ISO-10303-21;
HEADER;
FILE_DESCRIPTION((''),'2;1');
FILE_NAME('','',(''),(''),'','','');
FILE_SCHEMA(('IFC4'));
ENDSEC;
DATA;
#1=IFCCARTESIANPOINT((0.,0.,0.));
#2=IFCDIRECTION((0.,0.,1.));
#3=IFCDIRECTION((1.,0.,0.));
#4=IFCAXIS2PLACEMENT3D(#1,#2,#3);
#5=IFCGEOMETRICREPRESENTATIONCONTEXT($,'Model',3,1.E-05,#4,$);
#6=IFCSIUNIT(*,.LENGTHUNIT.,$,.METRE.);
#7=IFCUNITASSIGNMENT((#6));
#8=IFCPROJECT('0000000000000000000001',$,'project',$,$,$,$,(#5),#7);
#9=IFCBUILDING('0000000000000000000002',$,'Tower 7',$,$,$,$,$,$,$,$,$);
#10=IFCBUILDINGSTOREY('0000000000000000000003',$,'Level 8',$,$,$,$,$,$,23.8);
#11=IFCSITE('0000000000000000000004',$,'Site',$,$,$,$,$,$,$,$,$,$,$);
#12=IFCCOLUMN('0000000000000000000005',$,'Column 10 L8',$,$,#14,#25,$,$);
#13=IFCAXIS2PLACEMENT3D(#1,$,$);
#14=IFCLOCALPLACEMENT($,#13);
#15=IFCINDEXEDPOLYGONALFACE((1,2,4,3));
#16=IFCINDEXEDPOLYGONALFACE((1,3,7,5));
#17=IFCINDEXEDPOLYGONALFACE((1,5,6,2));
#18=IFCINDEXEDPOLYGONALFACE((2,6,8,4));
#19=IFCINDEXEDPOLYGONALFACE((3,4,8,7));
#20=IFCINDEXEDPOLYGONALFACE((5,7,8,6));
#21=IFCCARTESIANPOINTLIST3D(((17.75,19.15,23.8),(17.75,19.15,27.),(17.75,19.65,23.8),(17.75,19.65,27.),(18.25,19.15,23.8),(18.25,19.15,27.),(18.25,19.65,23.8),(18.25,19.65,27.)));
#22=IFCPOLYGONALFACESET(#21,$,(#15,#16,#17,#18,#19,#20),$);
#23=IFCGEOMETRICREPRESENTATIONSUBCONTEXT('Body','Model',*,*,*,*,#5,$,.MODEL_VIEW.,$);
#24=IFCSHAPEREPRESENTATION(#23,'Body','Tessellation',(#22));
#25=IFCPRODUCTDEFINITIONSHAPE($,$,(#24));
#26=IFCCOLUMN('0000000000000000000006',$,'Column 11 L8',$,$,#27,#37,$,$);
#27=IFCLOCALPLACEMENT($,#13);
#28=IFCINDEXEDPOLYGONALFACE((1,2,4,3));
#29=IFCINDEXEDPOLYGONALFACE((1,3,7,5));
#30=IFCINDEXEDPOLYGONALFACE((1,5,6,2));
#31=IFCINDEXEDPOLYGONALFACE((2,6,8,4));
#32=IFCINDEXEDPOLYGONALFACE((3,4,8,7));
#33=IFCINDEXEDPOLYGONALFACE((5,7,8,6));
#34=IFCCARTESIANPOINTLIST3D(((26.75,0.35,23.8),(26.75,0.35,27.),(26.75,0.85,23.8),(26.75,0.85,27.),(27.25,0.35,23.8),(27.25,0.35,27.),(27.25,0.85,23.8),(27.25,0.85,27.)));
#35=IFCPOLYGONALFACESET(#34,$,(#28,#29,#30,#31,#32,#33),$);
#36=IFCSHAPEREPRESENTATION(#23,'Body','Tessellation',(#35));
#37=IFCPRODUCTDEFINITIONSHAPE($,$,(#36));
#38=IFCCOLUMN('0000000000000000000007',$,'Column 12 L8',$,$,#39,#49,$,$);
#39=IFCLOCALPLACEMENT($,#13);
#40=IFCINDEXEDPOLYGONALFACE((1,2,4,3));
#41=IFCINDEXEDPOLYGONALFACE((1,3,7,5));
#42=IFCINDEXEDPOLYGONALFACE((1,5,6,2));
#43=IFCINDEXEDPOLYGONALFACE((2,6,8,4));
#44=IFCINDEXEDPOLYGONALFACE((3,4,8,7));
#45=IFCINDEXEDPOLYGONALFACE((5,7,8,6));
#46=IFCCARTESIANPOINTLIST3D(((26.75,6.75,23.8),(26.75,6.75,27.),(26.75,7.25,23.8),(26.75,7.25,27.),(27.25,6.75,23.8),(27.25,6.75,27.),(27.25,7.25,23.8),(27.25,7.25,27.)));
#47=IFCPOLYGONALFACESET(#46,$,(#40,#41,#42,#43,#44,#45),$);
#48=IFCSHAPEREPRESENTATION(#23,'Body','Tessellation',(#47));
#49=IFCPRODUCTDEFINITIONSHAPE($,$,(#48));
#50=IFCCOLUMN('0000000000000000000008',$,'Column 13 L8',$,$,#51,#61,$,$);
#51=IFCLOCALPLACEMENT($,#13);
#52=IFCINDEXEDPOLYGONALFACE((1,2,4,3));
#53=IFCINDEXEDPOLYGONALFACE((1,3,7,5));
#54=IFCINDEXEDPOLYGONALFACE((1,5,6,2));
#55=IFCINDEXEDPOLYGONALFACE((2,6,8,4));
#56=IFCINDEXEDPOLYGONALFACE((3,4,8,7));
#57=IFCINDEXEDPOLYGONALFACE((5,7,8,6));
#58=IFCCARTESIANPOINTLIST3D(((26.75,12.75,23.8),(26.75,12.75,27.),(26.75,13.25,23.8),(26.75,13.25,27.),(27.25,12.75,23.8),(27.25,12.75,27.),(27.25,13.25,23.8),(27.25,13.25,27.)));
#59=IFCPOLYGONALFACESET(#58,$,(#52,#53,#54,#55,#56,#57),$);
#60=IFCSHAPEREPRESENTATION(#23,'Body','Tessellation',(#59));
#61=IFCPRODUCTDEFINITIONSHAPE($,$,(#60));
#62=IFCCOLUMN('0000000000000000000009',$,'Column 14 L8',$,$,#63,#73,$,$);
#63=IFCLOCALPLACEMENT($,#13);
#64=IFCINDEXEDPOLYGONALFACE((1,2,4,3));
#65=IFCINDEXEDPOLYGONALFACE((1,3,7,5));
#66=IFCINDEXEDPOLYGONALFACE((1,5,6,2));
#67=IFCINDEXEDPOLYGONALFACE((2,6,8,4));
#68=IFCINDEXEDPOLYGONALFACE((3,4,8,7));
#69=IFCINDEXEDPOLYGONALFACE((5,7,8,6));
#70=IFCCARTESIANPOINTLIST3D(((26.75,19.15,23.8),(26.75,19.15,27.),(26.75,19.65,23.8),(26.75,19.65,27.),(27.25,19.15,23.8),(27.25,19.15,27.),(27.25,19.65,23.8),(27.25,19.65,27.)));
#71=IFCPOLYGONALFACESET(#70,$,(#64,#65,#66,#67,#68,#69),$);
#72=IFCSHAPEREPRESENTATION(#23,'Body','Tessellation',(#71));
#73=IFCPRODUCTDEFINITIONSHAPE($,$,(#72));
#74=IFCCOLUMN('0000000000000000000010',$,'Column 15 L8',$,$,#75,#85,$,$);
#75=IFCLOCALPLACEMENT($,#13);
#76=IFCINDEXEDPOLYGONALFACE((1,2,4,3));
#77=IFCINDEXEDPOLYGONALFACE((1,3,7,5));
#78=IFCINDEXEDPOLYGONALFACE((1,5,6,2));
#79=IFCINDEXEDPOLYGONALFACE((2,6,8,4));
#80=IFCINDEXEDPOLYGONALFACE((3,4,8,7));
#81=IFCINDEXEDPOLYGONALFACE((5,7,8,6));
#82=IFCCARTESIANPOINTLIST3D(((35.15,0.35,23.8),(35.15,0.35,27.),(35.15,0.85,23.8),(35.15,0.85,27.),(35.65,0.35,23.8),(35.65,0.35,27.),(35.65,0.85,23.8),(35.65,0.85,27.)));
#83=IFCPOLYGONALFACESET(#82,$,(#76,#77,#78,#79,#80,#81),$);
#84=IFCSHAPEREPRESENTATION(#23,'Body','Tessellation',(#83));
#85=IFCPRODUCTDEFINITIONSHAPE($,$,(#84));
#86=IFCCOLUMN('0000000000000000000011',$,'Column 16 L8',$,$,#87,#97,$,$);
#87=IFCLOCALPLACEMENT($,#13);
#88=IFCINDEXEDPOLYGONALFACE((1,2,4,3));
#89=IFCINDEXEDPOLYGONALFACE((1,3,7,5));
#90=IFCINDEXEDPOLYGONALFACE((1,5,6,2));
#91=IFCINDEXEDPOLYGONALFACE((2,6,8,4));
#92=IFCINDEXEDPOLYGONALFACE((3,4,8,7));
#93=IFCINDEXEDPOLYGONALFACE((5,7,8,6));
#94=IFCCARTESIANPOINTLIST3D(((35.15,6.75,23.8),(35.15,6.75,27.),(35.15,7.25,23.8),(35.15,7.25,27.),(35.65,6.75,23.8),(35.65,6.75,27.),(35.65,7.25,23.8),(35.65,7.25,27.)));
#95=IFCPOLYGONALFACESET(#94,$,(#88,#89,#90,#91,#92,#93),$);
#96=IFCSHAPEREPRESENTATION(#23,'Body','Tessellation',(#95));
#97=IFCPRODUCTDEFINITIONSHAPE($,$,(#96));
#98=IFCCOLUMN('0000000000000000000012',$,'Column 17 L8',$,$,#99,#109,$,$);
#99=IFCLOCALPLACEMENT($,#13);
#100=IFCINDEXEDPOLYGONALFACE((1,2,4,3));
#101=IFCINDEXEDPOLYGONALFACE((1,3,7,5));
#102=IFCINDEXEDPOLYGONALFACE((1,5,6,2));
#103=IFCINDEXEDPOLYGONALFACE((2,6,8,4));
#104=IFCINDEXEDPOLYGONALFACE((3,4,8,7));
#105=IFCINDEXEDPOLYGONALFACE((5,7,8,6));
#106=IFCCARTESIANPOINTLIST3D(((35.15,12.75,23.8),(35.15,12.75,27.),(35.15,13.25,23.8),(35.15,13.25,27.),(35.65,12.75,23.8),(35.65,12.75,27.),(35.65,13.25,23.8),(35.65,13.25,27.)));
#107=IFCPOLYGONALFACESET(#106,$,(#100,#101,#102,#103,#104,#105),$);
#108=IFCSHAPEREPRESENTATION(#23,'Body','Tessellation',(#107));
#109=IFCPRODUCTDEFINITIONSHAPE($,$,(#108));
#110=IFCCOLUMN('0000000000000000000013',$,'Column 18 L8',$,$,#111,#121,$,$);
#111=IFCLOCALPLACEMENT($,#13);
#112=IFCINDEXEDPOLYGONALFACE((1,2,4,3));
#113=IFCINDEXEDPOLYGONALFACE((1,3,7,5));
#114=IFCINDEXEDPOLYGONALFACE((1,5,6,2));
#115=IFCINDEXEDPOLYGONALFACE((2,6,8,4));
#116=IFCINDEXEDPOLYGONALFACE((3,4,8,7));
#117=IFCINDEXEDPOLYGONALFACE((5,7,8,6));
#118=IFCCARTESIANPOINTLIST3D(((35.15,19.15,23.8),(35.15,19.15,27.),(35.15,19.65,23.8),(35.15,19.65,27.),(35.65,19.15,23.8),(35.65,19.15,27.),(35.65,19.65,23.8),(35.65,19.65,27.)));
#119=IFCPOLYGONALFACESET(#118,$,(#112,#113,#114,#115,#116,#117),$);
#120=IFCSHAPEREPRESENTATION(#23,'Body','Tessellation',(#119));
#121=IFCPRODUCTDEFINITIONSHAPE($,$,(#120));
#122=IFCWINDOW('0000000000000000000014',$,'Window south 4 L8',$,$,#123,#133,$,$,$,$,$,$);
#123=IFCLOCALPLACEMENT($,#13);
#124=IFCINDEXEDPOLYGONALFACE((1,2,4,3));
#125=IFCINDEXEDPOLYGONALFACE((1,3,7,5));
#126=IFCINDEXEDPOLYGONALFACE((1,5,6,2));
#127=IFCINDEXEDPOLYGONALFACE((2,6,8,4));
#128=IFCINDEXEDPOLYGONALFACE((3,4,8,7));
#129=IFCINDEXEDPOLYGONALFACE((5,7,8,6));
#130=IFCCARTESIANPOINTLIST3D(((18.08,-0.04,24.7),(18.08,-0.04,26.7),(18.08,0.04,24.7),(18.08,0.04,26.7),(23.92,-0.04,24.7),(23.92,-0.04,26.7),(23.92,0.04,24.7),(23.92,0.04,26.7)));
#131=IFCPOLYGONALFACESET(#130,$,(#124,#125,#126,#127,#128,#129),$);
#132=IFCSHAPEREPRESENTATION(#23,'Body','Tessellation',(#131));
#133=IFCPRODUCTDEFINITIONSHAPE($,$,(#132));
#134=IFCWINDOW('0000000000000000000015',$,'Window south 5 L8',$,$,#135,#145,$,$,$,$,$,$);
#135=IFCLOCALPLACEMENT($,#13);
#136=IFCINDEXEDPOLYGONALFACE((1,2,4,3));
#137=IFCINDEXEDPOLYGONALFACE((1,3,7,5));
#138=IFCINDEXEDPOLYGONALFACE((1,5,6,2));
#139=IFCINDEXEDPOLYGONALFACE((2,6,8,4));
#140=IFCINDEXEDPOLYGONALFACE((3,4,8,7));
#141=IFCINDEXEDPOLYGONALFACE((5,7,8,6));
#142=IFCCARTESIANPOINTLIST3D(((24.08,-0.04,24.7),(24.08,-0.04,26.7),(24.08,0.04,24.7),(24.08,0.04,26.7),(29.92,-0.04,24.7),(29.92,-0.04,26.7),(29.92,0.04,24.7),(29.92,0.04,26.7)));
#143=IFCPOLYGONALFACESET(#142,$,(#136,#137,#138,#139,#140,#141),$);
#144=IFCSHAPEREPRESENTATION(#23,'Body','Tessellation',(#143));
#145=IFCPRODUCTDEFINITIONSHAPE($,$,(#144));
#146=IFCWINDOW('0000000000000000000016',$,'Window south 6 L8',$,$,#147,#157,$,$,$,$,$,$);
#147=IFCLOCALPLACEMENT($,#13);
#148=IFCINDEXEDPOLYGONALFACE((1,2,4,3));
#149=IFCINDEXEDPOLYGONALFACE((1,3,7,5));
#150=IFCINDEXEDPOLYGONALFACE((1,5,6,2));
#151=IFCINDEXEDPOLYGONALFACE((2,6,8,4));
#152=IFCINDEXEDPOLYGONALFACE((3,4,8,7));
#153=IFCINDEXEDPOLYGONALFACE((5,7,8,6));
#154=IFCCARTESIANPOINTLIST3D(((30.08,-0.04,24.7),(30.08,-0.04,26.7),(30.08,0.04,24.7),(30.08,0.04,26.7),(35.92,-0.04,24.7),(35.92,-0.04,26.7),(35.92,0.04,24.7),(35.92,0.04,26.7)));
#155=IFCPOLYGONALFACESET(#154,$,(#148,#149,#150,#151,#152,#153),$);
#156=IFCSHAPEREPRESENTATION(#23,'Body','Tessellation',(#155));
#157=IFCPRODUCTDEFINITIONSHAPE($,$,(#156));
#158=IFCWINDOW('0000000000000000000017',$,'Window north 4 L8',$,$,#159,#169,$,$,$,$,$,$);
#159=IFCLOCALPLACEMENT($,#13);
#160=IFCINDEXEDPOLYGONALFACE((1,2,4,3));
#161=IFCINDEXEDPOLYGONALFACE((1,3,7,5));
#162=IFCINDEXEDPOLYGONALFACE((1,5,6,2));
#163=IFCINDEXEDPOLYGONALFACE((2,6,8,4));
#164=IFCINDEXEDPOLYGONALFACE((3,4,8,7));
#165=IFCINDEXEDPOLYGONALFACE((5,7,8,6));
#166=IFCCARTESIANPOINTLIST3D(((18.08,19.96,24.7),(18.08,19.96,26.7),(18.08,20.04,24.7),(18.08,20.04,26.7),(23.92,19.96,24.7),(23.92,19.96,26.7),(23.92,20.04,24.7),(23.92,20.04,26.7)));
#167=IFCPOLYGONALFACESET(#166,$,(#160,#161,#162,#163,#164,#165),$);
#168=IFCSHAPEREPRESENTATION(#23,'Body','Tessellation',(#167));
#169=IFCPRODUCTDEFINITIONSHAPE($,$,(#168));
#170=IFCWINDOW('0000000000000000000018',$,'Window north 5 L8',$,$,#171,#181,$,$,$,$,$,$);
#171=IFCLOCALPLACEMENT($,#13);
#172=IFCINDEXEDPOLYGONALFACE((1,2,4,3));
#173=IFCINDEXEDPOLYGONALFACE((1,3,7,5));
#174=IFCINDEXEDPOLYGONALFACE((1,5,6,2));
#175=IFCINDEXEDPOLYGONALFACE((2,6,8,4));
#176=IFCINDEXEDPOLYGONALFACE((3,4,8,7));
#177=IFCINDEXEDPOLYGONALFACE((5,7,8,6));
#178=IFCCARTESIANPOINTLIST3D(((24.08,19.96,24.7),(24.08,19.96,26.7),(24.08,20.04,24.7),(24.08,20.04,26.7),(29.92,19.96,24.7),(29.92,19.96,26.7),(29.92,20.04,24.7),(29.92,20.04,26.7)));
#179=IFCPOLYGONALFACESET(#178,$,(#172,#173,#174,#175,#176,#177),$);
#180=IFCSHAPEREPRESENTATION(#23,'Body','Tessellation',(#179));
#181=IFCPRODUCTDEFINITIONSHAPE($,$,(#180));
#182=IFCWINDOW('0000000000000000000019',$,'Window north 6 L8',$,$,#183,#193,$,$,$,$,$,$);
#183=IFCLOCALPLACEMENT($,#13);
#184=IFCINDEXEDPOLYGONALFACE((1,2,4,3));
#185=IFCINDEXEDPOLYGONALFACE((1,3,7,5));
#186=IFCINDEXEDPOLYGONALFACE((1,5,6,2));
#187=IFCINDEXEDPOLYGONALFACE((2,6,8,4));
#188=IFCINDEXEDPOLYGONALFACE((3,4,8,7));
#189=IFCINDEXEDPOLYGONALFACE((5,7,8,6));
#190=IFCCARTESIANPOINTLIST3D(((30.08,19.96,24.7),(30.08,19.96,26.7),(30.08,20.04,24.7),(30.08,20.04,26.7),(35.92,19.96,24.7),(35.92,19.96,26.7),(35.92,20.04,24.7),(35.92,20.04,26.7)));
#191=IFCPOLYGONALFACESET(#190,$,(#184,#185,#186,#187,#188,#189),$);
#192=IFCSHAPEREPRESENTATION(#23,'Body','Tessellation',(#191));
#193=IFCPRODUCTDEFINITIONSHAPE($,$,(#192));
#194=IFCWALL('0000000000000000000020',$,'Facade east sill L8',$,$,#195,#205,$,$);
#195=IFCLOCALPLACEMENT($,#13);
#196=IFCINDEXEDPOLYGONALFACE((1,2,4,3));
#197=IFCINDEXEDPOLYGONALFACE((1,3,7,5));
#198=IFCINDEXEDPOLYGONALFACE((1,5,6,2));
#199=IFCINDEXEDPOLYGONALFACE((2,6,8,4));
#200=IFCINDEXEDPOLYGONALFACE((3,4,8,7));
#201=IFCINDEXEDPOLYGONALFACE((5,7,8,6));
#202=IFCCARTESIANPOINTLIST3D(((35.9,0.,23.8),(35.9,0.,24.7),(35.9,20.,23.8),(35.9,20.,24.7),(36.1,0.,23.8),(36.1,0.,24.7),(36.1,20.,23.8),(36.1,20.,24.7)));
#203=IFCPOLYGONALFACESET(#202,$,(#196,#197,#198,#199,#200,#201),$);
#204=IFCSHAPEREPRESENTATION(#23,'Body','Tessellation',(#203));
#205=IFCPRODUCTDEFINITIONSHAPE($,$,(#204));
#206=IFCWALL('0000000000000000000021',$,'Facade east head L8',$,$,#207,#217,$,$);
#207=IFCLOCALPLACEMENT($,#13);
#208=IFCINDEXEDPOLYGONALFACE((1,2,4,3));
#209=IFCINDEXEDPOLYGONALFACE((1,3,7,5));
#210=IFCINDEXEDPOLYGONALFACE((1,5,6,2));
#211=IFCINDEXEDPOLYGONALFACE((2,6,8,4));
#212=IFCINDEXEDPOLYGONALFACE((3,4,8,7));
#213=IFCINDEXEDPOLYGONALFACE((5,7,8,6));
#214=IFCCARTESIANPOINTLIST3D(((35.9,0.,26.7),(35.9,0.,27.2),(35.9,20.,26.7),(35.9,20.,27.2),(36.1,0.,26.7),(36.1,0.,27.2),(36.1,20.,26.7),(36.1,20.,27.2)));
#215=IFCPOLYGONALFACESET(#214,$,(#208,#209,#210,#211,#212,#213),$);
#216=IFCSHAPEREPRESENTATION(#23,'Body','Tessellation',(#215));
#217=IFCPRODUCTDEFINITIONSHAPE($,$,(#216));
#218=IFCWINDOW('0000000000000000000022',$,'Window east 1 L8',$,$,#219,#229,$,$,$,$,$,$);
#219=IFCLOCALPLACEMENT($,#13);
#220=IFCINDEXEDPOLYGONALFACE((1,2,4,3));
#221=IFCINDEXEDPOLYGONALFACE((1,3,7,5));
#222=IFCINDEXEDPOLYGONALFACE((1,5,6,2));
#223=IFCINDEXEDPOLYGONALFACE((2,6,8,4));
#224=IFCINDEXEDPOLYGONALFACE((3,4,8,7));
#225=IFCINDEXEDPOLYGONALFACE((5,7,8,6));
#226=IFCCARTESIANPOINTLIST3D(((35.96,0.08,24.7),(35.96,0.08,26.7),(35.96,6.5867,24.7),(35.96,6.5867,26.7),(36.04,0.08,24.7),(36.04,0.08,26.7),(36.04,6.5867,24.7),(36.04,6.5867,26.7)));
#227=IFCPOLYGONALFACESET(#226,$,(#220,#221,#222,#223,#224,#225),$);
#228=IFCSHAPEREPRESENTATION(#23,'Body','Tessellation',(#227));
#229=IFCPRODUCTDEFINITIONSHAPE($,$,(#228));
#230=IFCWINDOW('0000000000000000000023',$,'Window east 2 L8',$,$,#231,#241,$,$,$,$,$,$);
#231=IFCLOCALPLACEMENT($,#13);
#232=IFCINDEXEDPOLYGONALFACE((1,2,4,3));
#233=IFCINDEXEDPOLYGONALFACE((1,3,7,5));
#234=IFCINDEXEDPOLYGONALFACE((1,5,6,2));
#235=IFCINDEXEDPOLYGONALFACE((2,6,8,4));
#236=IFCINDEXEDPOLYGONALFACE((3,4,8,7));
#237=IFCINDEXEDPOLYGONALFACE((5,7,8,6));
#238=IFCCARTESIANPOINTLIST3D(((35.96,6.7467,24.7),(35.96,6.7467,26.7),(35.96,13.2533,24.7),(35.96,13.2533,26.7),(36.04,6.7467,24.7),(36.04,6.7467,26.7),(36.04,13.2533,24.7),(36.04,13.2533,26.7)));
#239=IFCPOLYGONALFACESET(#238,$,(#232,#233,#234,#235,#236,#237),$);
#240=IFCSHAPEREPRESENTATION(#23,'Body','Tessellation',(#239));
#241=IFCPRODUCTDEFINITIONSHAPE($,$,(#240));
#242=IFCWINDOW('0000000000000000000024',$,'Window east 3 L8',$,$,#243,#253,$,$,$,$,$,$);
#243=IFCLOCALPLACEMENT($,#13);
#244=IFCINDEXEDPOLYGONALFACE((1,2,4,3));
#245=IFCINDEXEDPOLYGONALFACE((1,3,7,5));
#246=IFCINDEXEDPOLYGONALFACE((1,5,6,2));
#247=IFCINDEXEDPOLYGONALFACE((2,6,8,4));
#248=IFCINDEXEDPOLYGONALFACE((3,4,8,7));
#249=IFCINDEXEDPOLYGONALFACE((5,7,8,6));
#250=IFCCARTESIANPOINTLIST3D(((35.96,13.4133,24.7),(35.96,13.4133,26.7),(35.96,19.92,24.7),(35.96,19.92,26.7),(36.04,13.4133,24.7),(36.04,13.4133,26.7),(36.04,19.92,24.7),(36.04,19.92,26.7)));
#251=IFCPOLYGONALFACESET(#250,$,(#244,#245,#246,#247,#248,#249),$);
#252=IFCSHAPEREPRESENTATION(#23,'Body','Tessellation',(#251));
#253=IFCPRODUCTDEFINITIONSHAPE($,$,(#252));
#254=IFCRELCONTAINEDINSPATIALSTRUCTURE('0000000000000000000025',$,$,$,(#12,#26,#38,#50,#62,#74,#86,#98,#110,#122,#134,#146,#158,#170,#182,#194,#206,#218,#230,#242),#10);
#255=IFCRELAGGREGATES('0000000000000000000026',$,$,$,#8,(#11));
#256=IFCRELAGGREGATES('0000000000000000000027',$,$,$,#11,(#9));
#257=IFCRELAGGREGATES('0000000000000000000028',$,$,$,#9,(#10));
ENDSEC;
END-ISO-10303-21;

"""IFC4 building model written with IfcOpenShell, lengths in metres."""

from ifc_helpers import new_model, si_unit, frame, origin, origin_with_axes, origin_2d, place, context, subcontext, project, spatial, rectangle, extrude, element, save


model = new_model("IFC4")

# Units and contexts
model_context = context("Model", 3, precision=1e-05, world=origin_with_axes())
body_context = subcontext(model_context, "Body", "Model", "MODEL_VIEW")
ifc_project = project(units=[si_unit("LENGTHUNIT", "METRE")], contexts=[model_context])

# Site, building, storey
site = spatial("IfcSite", under=ifc_project, Name="Site")
building = spatial("IfcBuilding", under=site, Name="Tower 7")
storey = spatial("IfcBuildingStorey", under=building, Name="Level 8", Elevation=23.8)

# Columns
for number, where, z_axis, x_axis, name in (
    (1, (18.0, 19.4, 23.8), (0.0, 0.0, 1.0), (1.0, 0.0, 0.0), "Column 10 L8"),
    (2, (27.0, 0.6, 23.8), (0.0, 0.0, 1.0), (1.0, 0.0, 0.0), "Column 11 L8"),
    (3, (27.0, 7.0, 23.8), (0.0, 0.0, 1.0), (1.0, 0.0, 0.0), "Column 12 L8"),
    (4, (27.0, 13.0, 23.8), (0.0, 0.0, 1.0), (1.0, 0.0, 0.0), "Column 13 L8"),
    (5, (27.0, 19.4, 23.8), (0.0, 0.0, 1.0), (1.0, 0.0, 0.0), "Column 14 L8"),
    (6, (35.4, 0.6, 23.8), (0.0, 0.0, 1.0), (1.0, 0.0, 0.0), "Column 15 L8"),
    (7, (35.4, 7.0, 23.8), (0.0, 0.0, 1.0), (1.0, 0.0, 0.0), "Column 16 L8"),
    (8, (35.4, 13.0, 23.8), (0.0, 0.0, 1.0), (1.0, 0.0, 0.0), "Column 17 L8"),
    (9, (35.4, 19.4, 23.8), (0.0, 0.0, 1.0), (1.0, 0.0, 0.0), "Column 18 L8"),
):
    element("IfcColumn", number, at=place(None, frame(where, z_axis=z_axis, x_axis=x_axis)), inside=storey, Name=name, context=body_context, shape_type="SweptSolid", body=[
        extrude(rectangle(XDim=0.5, YDim=0.5, at=origin_2d()), origin(), (0.0, 0.0, 1.0), 3.2),
    ])

# Windows
for number, where, z_axis, x_axis, name in (
    (10, (21.0, 0.0, 24.7), (0.0, 0.0, 1.0), (1.0, 0.0, 0.0), "Window south 4 L8"),
    (11, (27.0, 0.0, 24.7), (0.0, 0.0, 1.0), (1.0, 0.0, 0.0), "Window south 5 L8"),
    (12, (33.0, 0.0, 24.7), (0.0, 0.0, 1.0), (1.0, 0.0, 0.0), "Window south 6 L8"),
):
    element("IfcWindow", number, at=place(None, frame(where, z_axis=z_axis, x_axis=x_axis)), inside=storey, Name=name, context=body_context, shape_type="SweptSolid", body=[
        extrude(rectangle(XDim=5.84, YDim=0.08, at=origin_2d()), origin(), (0.0, 0.0, 1.0), 2.0),
    ])
for number, where, z_axis, x_axis, name in (
    (13, (21.0, 20.0, 24.7), (0.0, 0.0, 1.0), (1.0, 0.0, 0.0), "Window north 4 L8"),
    (14, (27.0, 20.0, 24.7), (0.0, 0.0, 1.0), (1.0, 0.0, 0.0), "Window north 5 L8"),
    (15, (33.0, 20.0, 24.7), (0.0, 0.0, 1.0), (1.0, 0.0, 0.0), "Window north 6 L8"),
):
    element("IfcWindow", number, at=place(None, frame(where, z_axis=z_axis, x_axis=x_axis)), inside=storey, Name=name, context=body_context, shape_type="SweptSolid", body=[
        extrude(rectangle(XDim=5.84, YDim=0.08, at=origin_2d()), origin(), (0.0, 0.0, 1.0), 2.0),
    ])

# Walls
wall_1_placement = place(None, frame((36.0, 10.0, 23.8), z_axis=(0.0, 0.0, 1.0), x_axis=(1.0, 0.0, 0.0)))
element("IfcWall", 16, at=wall_1_placement, inside=storey, Name="Facade east sill L8", context=body_context, shape_type="SweptSolid", body=[
    extrude(rectangle(XDim=0.2, YDim=20.0, at=origin_2d()), origin(), (0.0, 0.0, 1.0), 0.9),
])
wall_2_placement = place(None, frame((36.0, 10.0, 26.7), z_axis=(0.0, 0.0, 1.0), x_axis=(1.0, 0.0, 0.0)))
element("IfcWall", 17, at=wall_2_placement, inside=storey, Name="Facade east head L8", context=body_context, shape_type="SweptSolid", body=[
    extrude(rectangle(XDim=0.2, YDim=20.0, at=origin_2d()), origin(), (0.0, 0.0, 1.0), 0.5),
])

# Windows
for number, where, z_axis, x_axis, name in (
    (18, (36.0, 3.3333, 24.7), (0.0, 0.0, 1.0), (1.0, 0.0, 0.0), "Window east 1 L8"),
    (19, (36.0, 10.0, 24.7), (0.0, 0.0, 1.0), (1.0, 0.0, 0.0), "Window east 2 L8"),
):
    element("IfcWindow", number, at=place(None, frame(where, z_axis=z_axis, x_axis=x_axis)), inside=storey, Name=name, context=body_context, shape_type="SweptSolid", body=[
        extrude(rectangle(XDim=0.08, YDim=6.5067, at=origin_2d()), origin(), (0.0, 0.0, 1.0), 2.0),
    ])
window_placement = place(None, frame((36.0, 16.6667, 24.7), z_axis=(0.0, 0.0, 1.0), x_axis=(1.0, 0.0, 0.0)))
element("IfcWindow", 20, at=window_placement, inside=storey, Name="Window east 3 L8", context=body_context, shape_type="SweptSolid", body=[
    extrude(rectangle(XDim=0.08, YDim=6.5067, at=origin_2d()), origin(), (0.0, 0.0, 1.0), 2.0),
])

save(model, "model.ifc")
